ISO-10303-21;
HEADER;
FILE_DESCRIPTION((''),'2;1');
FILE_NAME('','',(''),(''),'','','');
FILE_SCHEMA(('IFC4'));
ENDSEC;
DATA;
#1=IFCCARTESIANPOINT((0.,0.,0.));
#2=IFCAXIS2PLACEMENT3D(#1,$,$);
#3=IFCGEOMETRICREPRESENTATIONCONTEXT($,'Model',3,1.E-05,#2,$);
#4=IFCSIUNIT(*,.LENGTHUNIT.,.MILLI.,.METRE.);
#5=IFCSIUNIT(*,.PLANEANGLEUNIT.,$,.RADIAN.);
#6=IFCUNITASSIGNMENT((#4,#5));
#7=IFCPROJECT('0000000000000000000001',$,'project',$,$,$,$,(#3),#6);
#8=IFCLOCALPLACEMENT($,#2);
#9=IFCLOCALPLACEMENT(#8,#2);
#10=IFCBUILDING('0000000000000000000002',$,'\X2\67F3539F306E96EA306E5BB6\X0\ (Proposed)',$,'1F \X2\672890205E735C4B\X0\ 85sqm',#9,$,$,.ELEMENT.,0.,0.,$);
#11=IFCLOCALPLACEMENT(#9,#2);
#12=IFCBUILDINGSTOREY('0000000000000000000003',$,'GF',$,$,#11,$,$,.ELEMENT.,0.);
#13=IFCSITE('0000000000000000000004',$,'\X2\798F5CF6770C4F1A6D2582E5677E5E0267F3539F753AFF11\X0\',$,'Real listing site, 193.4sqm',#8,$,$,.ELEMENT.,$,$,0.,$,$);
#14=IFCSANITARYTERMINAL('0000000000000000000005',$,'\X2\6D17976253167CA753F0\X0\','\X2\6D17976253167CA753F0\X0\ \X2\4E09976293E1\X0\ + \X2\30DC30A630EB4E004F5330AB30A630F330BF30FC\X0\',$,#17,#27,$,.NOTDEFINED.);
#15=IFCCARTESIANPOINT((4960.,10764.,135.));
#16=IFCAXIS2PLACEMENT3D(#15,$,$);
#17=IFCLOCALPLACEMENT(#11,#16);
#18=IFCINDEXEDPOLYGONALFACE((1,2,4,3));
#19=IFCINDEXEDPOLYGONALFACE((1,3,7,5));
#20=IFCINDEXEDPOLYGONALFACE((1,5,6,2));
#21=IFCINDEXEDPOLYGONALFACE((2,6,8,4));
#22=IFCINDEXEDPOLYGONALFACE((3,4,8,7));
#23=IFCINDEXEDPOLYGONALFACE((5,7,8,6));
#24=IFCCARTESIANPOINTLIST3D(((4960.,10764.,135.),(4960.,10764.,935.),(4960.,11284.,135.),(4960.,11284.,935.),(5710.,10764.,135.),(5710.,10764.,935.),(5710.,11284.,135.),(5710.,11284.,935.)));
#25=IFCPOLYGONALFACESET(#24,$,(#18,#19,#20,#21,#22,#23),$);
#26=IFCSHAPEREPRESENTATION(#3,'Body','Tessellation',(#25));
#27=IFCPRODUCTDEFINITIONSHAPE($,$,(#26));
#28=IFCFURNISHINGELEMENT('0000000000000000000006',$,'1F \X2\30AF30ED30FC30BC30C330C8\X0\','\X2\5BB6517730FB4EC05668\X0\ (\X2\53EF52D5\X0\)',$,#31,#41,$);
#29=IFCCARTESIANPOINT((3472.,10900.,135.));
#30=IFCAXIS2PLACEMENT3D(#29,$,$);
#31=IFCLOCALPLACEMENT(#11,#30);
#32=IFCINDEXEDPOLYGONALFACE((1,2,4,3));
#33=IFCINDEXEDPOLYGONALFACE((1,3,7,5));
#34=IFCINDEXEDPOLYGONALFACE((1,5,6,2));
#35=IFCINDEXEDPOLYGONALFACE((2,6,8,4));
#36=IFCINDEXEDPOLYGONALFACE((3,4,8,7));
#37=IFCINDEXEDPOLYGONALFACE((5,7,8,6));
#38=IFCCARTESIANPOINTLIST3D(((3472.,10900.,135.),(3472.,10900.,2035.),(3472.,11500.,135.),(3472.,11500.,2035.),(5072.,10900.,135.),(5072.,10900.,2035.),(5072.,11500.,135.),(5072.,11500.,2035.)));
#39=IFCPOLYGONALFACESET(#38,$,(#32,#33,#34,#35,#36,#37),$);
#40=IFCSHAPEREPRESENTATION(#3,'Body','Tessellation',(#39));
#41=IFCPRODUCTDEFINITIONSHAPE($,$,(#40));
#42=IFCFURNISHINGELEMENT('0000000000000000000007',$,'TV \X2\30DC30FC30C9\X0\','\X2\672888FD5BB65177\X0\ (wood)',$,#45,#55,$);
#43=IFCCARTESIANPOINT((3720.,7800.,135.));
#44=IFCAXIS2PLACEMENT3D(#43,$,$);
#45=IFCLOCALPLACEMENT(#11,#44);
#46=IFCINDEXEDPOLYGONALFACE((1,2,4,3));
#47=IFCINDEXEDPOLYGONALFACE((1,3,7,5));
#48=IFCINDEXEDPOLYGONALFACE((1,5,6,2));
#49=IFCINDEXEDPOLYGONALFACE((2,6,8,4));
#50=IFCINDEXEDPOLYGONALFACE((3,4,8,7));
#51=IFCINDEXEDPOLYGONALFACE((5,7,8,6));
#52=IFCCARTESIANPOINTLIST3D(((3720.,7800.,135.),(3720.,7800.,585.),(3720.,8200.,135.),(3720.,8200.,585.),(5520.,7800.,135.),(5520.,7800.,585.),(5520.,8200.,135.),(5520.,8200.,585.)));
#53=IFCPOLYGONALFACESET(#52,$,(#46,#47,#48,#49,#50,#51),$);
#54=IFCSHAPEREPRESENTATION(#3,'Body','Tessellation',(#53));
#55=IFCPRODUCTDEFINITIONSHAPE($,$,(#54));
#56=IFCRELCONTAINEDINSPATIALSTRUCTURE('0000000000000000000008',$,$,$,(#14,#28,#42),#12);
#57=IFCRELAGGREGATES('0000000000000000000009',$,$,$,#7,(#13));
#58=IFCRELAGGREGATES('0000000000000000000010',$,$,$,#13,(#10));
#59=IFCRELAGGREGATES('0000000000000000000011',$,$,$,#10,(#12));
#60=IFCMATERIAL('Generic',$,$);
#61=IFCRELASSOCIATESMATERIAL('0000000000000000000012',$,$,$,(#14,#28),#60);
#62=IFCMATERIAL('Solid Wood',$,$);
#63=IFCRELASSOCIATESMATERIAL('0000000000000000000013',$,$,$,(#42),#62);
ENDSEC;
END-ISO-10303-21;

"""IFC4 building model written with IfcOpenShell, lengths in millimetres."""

from ifc_helpers import new_model, si_unit, frame, frame_2d, origin, place, context, project, spatial, rectangle, extrude, material, element, save


model = new_model("IFC4")

# Units and contexts
model_context = context("Model", 3, precision=1e-05, world=origin())
ifc_project = project(units=[si_unit("LENGTHUNIT", "METRE", prefix="MILLI"), si_unit("PLANEANGLEUNIT", "RADIAN")], contexts=[model_context])

# Site, building, storey
site_placement = place(None, origin())
site = spatial("IfcSite", under=ifc_project, at=site_placement, Name="福島県会津若松市柳原町１", ObjectType="Real listing site, 193.4sqm", CompositionType="ELEMENT", RefElevation=0.0)
building_placement = place(site_placement, origin())
building = spatial("IfcBuilding", under=site, at=building_placement, Name="柳原の雪の家 (Proposed)", ObjectType="1F 木造平屋 85sqm", CompositionType="ELEMENT", ElevationOfRefHeight=0.0, ElevationOfTerrain=0.0)
storey_placement = place(building_placement, origin())
storey = spatial("IfcBuildingStorey", under=building, at=storey_placement, Name="GF", CompositionType="ELEMENT", Elevation=0.0)

# Shared definitions
ifc_material_1 = material(Name="Solid Wood")

# Shared definitions
ifc_material_2 = material(Name="Generic")

# Sanitary terminal
sanitary_terminal_1_placement = place(storey_placement, frame((4960.0, 10764.0, 135.0)))
element("IfcSanitaryTerminal", 1, at=sanitary_terminal_1_placement, inside=storey, material=ifc_material_2, Name="洗面化粧台", Description="洗面化粧台 三面鏡 + ボウル一体カウンター", PredefinedType="NOTDEFINED", context=model_context, shape_type="SweptSolid", body=[
    extrude(rectangle(XDim=750.0, YDim=520.0, at=frame_2d((375.0, 260.0))), frame((4960.0, 10764.0, 135.0)), (0.0, 0.0, 1.0), 800.0),
])

# Furnishing elements
furnishing_1_placement = place(storey_placement, frame((3472.0, 10900.0, 135.0)))
element("IfcFurnishingElement", 2, at=furnishing_1_placement, inside=storey, material=ifc_material_2, Name="1F クローゼット", Description="家具・什器 (可動)", context=model_context, shape_type="SweptSolid", body=[
    extrude(rectangle(XDim=1600.0, YDim=600.0, at=frame_2d((800.0, 300.0))), frame((3472.0, 10900.0, 135.0)), (0.0, 0.0, 1.0), 1900.0),
])
furnishing_2_placement = place(storey_placement, frame((3720.0, 7800.0, 135.0)))
element("IfcFurnishingElement", 3, at=furnishing_2_placement, inside=storey, material=ifc_material_1, Name="TV ボード", Description="木製家具 (wood)", context=model_context, shape_type="SweptSolid", body=[
    extrude(rectangle(XDim=1800.0, YDim=400.0, at=frame_2d((900.0, 200.0))), frame((3720.0, 7800.0, 135.0)), (0.0, 0.0, 1.0), 450.0),
])

save(model, "model.ifc")
